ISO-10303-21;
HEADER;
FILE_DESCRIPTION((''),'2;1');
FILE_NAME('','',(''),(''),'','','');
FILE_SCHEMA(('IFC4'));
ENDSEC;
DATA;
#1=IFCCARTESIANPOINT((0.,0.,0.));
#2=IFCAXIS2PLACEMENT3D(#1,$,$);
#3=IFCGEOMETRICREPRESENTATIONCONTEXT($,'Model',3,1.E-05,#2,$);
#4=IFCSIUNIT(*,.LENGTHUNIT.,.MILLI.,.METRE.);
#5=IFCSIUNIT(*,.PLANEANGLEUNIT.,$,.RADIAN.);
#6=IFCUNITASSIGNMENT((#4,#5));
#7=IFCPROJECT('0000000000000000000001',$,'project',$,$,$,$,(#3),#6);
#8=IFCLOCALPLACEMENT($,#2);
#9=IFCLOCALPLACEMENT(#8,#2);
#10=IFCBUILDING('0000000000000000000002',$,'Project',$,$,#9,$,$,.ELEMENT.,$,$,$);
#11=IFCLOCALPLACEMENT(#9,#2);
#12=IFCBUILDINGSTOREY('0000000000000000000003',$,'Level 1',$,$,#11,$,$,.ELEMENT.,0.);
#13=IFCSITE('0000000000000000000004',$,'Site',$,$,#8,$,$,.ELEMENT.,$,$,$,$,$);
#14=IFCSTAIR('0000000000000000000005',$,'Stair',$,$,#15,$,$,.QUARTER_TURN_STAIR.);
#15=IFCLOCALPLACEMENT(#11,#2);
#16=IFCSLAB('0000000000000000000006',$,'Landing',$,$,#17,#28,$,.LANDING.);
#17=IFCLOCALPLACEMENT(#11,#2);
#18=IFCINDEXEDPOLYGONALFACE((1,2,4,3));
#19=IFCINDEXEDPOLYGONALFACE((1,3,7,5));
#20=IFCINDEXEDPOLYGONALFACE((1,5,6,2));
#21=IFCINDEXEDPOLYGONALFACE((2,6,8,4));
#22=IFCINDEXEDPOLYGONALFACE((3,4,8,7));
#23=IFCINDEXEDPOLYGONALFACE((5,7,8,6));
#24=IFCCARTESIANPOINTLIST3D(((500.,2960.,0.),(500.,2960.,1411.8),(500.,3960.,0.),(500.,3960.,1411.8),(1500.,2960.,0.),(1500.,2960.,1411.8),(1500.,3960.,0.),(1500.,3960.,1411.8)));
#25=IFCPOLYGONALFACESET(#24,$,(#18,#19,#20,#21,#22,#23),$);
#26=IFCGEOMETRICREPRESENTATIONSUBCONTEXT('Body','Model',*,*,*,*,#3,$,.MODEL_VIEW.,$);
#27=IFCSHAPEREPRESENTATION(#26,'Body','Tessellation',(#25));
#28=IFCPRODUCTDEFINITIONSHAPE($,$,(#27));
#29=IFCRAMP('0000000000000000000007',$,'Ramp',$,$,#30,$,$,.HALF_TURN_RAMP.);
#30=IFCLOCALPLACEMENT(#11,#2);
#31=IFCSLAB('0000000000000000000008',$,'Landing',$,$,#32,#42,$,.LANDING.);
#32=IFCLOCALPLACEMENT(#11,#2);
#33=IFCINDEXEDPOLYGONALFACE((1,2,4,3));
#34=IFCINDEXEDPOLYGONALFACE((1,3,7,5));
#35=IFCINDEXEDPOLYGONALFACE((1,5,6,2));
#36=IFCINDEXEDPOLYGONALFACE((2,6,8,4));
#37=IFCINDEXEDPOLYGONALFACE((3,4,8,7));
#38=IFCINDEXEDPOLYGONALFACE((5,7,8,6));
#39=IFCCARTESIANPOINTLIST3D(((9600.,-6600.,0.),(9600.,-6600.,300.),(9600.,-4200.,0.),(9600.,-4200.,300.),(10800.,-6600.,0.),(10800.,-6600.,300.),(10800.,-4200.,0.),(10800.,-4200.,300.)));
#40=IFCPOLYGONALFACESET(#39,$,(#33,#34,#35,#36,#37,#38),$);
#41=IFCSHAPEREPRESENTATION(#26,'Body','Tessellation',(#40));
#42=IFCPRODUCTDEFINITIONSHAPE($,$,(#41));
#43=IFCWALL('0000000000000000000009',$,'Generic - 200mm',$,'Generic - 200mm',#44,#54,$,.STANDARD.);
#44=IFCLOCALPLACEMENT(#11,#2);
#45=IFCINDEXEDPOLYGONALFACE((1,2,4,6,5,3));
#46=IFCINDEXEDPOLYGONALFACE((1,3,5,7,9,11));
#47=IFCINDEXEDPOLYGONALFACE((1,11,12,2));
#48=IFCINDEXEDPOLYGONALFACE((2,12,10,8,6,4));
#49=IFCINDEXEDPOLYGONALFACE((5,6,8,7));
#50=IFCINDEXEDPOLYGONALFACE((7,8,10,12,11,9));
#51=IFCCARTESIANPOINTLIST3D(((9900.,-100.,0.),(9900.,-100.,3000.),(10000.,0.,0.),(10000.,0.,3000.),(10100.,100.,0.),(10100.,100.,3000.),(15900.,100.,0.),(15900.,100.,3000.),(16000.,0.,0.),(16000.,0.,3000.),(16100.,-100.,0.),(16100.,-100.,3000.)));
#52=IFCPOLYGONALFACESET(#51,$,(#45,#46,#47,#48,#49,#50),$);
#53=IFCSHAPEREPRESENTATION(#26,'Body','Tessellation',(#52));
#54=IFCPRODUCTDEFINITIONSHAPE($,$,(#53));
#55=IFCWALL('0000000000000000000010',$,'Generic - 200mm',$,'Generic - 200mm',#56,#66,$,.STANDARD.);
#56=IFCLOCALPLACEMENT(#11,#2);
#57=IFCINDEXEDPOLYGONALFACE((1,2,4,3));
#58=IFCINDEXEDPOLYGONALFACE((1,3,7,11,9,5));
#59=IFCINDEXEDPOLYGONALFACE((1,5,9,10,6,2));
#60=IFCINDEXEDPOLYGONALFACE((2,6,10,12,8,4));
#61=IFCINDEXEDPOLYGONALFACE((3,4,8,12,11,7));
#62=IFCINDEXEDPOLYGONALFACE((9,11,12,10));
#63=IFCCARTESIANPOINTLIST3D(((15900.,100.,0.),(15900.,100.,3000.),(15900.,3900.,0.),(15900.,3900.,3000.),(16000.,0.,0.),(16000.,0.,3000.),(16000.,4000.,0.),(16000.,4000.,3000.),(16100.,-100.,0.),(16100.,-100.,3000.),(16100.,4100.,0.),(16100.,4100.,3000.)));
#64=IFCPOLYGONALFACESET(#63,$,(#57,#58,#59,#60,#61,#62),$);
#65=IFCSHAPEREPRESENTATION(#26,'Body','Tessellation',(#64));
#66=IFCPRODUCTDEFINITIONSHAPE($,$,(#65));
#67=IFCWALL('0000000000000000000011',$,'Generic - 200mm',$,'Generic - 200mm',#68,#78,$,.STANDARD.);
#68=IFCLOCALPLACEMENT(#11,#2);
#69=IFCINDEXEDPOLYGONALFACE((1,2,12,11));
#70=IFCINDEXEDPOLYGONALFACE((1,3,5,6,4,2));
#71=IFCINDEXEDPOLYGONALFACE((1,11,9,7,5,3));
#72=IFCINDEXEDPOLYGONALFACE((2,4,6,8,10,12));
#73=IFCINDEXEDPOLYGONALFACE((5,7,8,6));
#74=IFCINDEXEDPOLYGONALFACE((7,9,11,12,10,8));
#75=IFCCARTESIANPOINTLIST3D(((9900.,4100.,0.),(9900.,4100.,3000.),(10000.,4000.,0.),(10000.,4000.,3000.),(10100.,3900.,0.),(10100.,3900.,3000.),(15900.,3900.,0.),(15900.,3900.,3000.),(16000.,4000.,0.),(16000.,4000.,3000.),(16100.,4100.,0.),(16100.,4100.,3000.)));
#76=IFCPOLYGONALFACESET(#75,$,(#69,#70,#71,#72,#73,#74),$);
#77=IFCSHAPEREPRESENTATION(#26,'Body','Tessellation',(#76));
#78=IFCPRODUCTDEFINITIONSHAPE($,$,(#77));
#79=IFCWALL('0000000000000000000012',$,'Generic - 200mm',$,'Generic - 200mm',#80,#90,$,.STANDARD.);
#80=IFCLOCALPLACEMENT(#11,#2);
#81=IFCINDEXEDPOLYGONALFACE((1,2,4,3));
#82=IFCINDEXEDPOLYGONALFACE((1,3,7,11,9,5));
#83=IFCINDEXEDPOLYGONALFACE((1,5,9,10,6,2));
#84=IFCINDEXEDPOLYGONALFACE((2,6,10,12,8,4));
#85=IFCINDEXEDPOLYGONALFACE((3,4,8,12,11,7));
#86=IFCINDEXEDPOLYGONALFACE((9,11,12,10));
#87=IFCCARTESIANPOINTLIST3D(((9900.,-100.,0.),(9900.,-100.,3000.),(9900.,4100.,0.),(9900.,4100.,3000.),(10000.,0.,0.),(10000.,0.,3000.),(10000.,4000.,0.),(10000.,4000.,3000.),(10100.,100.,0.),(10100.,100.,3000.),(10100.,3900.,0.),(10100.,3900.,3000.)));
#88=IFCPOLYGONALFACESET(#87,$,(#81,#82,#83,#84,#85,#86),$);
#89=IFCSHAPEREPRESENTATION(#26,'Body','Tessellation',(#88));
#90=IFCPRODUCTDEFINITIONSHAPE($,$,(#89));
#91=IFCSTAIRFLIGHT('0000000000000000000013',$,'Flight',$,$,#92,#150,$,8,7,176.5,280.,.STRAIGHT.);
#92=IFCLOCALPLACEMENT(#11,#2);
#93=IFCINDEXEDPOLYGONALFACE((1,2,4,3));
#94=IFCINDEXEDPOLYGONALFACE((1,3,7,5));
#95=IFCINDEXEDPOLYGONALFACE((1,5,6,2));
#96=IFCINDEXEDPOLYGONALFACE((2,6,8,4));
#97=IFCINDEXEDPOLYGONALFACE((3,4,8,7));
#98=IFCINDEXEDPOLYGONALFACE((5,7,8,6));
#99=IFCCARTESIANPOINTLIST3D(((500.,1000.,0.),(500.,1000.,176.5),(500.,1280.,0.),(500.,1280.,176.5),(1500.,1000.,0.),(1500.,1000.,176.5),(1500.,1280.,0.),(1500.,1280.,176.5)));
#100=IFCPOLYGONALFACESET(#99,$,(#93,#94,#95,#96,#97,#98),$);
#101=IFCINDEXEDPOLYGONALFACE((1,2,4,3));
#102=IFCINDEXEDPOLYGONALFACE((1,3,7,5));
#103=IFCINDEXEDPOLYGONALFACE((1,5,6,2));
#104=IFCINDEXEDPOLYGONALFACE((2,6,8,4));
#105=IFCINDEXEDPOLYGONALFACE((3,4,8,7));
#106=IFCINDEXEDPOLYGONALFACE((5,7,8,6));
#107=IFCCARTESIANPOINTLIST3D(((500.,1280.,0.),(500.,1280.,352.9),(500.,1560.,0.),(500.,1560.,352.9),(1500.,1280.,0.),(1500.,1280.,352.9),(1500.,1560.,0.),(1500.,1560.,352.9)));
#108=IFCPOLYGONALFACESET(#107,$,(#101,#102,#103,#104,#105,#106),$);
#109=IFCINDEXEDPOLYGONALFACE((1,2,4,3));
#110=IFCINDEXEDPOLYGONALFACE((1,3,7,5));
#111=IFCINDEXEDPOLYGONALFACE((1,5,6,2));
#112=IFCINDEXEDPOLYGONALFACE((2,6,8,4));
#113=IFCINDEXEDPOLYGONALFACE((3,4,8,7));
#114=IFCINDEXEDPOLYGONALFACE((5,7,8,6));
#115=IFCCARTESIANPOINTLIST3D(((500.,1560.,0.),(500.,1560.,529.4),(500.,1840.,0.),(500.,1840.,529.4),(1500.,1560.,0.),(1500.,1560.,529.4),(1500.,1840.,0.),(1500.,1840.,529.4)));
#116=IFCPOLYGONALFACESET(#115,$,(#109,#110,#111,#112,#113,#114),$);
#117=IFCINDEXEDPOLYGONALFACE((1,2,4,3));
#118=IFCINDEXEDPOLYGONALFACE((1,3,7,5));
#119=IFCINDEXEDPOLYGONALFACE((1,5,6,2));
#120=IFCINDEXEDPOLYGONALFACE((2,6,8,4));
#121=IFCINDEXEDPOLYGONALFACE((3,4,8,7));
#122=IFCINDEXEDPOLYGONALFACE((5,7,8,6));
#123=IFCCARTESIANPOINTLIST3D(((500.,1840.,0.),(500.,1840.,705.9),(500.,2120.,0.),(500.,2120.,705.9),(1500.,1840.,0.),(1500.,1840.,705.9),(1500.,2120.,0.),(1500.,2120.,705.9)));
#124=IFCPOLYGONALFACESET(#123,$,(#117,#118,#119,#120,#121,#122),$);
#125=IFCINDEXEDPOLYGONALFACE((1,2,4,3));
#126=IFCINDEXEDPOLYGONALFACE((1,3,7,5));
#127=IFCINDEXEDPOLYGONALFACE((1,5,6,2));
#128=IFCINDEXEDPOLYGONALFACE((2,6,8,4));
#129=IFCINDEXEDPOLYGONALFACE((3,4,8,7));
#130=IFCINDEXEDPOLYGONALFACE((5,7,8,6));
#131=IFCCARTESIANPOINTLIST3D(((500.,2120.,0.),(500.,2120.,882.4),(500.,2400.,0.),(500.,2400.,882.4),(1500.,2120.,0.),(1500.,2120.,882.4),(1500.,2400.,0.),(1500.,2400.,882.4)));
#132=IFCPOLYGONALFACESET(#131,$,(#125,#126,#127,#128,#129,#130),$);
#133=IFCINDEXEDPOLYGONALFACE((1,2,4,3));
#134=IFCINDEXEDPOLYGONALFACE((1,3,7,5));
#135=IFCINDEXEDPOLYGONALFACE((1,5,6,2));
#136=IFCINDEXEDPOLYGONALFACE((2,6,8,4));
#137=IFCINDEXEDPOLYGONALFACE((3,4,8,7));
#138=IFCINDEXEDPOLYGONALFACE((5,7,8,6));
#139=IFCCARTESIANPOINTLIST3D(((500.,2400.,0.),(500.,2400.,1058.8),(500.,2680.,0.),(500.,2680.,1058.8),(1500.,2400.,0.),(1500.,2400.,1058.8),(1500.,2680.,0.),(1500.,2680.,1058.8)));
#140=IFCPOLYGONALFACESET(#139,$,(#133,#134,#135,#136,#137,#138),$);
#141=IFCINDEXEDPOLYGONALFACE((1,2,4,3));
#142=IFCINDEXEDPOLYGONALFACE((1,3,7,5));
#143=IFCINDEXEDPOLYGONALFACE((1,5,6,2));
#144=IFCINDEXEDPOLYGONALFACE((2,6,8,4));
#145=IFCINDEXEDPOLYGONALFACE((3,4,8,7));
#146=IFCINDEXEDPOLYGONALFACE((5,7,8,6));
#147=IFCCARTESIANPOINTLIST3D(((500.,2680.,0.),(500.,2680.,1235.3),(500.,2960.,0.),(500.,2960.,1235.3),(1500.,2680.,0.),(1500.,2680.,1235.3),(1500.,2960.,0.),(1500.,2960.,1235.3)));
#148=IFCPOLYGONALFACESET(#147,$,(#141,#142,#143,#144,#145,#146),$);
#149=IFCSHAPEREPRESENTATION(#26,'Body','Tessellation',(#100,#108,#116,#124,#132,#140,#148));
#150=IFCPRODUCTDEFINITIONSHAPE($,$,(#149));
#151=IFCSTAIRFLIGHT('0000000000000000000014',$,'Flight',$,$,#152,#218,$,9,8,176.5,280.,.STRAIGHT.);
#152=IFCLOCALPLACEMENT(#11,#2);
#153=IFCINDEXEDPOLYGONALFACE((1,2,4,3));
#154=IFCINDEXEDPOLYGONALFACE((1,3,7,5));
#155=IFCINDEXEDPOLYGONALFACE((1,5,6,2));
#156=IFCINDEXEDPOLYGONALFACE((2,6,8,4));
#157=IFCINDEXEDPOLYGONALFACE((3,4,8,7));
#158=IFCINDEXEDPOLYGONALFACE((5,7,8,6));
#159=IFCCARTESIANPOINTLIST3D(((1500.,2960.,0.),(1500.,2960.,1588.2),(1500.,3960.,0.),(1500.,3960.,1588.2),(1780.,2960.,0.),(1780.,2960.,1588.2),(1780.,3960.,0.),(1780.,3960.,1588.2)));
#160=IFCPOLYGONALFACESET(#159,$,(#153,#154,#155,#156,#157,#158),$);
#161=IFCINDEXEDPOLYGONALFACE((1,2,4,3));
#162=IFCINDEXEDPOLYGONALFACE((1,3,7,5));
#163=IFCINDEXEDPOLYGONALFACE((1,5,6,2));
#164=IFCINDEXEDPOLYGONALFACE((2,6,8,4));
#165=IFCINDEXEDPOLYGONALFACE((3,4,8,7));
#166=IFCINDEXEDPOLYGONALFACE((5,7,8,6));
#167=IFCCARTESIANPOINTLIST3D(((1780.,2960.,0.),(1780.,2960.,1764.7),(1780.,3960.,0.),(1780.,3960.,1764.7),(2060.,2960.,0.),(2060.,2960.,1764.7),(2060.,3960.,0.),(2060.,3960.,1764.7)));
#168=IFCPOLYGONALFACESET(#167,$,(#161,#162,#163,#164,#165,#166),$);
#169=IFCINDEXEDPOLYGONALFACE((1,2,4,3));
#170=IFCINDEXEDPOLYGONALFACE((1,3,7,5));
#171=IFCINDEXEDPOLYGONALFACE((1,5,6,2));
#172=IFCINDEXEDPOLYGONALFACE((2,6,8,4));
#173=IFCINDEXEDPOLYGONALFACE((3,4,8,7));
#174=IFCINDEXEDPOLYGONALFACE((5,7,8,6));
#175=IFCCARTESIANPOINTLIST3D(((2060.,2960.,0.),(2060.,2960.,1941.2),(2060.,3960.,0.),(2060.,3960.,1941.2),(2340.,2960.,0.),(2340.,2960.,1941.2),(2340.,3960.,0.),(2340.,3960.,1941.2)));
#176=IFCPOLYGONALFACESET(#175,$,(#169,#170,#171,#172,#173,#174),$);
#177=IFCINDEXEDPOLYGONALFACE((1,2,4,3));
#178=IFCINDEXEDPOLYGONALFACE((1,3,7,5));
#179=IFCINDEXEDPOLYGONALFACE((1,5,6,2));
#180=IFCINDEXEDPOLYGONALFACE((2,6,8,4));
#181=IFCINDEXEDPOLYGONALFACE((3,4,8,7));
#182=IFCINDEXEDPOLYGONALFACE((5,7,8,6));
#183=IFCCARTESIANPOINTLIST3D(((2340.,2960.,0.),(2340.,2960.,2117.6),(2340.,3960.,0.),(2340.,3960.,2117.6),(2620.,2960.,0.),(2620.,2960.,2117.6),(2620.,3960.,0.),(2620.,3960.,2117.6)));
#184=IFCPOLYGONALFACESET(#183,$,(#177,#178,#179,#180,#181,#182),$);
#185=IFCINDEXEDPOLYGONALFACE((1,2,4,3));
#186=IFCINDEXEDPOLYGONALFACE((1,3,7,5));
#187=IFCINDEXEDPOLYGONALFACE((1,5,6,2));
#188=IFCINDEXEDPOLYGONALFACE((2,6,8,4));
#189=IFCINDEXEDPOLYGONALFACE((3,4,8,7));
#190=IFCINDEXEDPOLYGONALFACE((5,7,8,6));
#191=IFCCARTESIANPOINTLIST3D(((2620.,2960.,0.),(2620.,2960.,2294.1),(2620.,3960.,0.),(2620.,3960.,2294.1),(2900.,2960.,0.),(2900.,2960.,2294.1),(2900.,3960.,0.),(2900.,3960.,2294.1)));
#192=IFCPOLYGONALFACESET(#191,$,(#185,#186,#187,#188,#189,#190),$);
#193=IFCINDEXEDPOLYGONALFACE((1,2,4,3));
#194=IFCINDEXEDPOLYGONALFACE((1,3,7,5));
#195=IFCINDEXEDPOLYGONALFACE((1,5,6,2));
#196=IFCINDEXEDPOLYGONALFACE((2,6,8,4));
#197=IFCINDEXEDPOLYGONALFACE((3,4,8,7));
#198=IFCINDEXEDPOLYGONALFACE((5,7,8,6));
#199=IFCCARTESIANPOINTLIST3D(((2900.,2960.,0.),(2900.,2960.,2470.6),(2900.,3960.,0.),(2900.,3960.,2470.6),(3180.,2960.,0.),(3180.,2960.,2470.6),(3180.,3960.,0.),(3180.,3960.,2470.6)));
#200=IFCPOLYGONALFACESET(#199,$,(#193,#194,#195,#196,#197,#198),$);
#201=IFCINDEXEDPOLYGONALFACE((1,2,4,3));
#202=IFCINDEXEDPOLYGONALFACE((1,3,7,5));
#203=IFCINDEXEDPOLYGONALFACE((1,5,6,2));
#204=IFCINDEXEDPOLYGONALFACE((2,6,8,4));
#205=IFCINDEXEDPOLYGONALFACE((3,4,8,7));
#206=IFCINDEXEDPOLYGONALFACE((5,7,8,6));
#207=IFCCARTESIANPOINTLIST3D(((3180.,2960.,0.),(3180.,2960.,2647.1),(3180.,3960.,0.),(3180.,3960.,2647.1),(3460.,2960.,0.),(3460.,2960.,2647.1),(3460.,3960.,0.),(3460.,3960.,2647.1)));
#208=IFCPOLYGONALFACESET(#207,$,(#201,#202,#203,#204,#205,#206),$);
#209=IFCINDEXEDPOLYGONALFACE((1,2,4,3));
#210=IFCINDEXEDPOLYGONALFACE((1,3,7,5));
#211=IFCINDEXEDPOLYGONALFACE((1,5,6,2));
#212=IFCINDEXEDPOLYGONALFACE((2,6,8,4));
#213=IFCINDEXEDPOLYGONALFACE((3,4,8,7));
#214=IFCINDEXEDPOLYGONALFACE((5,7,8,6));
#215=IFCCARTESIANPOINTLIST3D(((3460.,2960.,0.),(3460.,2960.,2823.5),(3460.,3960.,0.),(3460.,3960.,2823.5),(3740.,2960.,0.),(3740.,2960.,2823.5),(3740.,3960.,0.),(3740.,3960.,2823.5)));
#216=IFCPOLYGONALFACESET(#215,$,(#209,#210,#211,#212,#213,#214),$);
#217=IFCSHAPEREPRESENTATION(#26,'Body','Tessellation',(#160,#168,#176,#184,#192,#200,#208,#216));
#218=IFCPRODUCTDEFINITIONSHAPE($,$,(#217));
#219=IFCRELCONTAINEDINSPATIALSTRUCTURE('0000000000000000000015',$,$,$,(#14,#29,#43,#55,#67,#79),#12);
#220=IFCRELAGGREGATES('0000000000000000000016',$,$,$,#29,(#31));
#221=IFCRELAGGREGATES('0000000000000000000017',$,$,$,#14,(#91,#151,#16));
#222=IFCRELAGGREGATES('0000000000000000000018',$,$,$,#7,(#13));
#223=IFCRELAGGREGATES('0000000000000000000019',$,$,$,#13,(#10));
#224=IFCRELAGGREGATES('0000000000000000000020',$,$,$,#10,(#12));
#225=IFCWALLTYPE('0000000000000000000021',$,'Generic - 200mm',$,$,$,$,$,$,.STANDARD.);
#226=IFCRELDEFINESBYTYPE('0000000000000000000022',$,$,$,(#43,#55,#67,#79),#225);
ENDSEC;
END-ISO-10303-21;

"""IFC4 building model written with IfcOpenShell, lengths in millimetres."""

from ifc_helpers import new_model, si_unit, frame, frame_2d, origin, place, context, subcontext, project, spatial, polyline, rectangle, outline, extrude, type_object, element, aggregate, save


model = new_model("IFC4")

# Units and contexts
model_context = context("Model", 3, precision=1e-05, world=origin())
body_context = subcontext(model_context, "Body", "Model", "MODEL_VIEW")
ifc_project = project(units=[si_unit("LENGTHUNIT", "METRE", prefix="MILLI"), si_unit("PLANEANGLEUNIT", "RADIAN")], contexts=[model_context])

# Site, building, storey
site_placement = place(None, origin())
site = spatial("IfcSite", under=ifc_project, at=site_placement, Name="Site", CompositionType="ELEMENT")
building_placement = place(site_placement, origin())
building = spatial("IfcBuilding", under=site, at=building_placement, Name="Project", CompositionType="ELEMENT")
storey_placement = place(building_placement, origin())
storey = spatial("IfcBuildingStorey", under=building, at=storey_placement, Name="Level 1", CompositionType="ELEMENT", Elevation=0.0)

# Stair, slab
stair_placement = place(storey_placement, origin())
stair = element("IfcStair", 1, at=stair_placement, inside=storey, Name="Stair", PredefinedType="QUARTER_TURN_STAIR")
slab_1_placement = place(stair_placement, origin())
slab_1 = element("IfcSlab", 2, at=slab_1_placement, Name="Landing", PredefinedType="LANDING", context=body_context, shape_type="SweptSolid", body=[
    extrude(outline(polyline([(1500.0, 2960.0), (1500.0, 3960.0), (500.0, 3960.0), (500.0, 2960.0), (1500.0, 2960.0)])), origin(), (0.0, 0.0, 1.0), 1411.8),
])

# Ramp, slab
ramp_placement = place(storey_placement, origin())
ramp = element("IfcRamp", 3, at=ramp_placement, inside=storey, Name="Ramp", PredefinedType="HALF_TURN_RAMP")
slab_2_placement = place(ramp_placement, origin())
slab_2 = element("IfcSlab", 4, at=slab_2_placement, Name="Landing", PredefinedType="LANDING", context=body_context, shape_type="SweptSolid", body=[
    extrude(outline(polyline([(9600.0, -6600.0), (10800.0, -6600.0), (10800.0, -4200.0), (9600.0, -4200.0), (9600.0, -6600.0)])), origin(), (0.0, 0.0, 1.0), 300.0),
])
aggregate(ramp, [slab_2])

# Walls
wall_type = type_object("IfcWallType", Name="Generic - 200mm", PredefinedType="STANDARD")
wall_1_placement = place(storey_placement, frame((10000.0, 0.0, 0.0), z_axis=(0.0, 0.0, 1.0), x_axis=(1.0, 0.0, 0.0)))
element("IfcWall", 5, at=wall_1_placement, inside=storey, type_object=wall_type, Name="Generic - 200mm", ObjectType="Generic - 200mm", PredefinedType="STANDARD", context=body_context, shape_type="SweptSolid", body=[
    extrude(outline(polyline([(-100.0, -100.0), (0.0, 0.0), (100.0, 100.0), (5900.0, 100.0), (6000.0, 0.0), (6100.0, -100.0), (-100.0, -100.0)])), origin(), (0.0, 0.0, 1.0), 3000.0),
])
wall_2_placement = place(storey_placement, frame((16000.0, 0.0, 0.0), z_axis=(0.0, 0.0, 1.0), x_axis=(0.0, 1.0, 0.0)))
element("IfcWall", 6, at=wall_2_placement, inside=storey, type_object=wall_type, Name="Generic - 200mm", ObjectType="Generic - 200mm", PredefinedType="STANDARD", context=body_context, shape_type="SweptSolid", body=[
    extrude(outline(polyline([(-100.0, -100.0), (0.0, 0.0), (100.0, 100.0), (3900.0, 100.0), (4000.0, 0.0), (4100.0, -100.0), (-100.0, -100.0)])), origin(), (0.0, 0.0, 1.0), 3000.0),
])
wall_3_placement = place(storey_placement, frame((16000.0, 4000.0, 0.0), z_axis=(0.0, 0.0, 1.0), x_axis=(-1.0, 0.0, 0.0)))
element("IfcWall", 7, at=wall_3_placement, inside=storey, type_object=wall_type, Name="Generic - 200mm", ObjectType="Generic - 200mm", PredefinedType="STANDARD", context=body_context, shape_type="SweptSolid", body=[
    extrude(outline(polyline([(-100.0, -100.0), (0.0, 0.0), (100.0, 100.0), (5900.0, 100.0), (6000.0, 0.0), (6100.0, -100.0), (-100.0, -100.0)])), origin(), (0.0, 0.0, 1.0), 3000.0),
])
wall_4_placement = place(storey_placement, frame((10000.0, 4000.0, 0.0), z_axis=(0.0, 0.0, 1.0), x_axis=(0.0, -1.0, 0.0)))
element("IfcWall", 8, at=wall_4_placement, inside=storey, type_object=wall_type, Name="Generic - 200mm", ObjectType="Generic - 200mm", PredefinedType="STANDARD", context=body_context, shape_type="SweptSolid", body=[
    extrude(outline(polyline([(-100.0, -100.0), (0.0, 0.0), (100.0, 100.0), (3900.0, 100.0), (4000.0, 0.0), (4100.0, -100.0), (-100.0, -100.0)])), origin(), (0.0, 0.0, 1.0), 3000.0),
])

# Stair flights
stair_flight_1_placement = place(stair_placement, frame((1000.0, 1000.0, 0.0), z_axis=(0.0, 0.0, 1.0), x_axis=(0.0, 1.0, 0.0)))
stair_flight_1 = element("IfcStairFlight", 9, at=stair_flight_1_placement, Name="Flight", NumberOfRisers=8, NumberOfTreads=7, PredefinedType="STRAIGHT", RiserHeight=176.5, TreadLength=280.0, context=body_context, shape_type="SweptSolid", body=[
    extrude(rectangle(XDim=280.0, YDim=1000.0, at=frame_2d((140.0, 0.0))), origin(), (0.0, 0.0, 1.0), 176.5),
    extrude(rectangle(XDim=280.0, YDim=1000.0, at=frame_2d((420.0, 0.0))), origin(), (0.0, 0.0, 1.0), 352.9),
    extrude(rectangle(XDim=280.0, YDim=1000.0, at=frame_2d((700.0, 0.0))), origin(), (0.0, 0.0, 1.0), 529.4),
    extrude(rectangle(XDim=280.0, YDim=1000.0, at=frame_2d((980.0, 0.0))), origin(), (0.0, 0.0, 1.0), 705.9),
    extrude(rectangle(XDim=280.0, YDim=1000.0, at=frame_2d((1260.0, 0.0))), origin(), (0.0, 0.0, 1.0), 882.4),
    extrude(rectangle(XDim=280.0, YDim=1000.0, at=frame_2d((1540.0, 0.0))), origin(), (0.0, 0.0, 1.0), 1058.8),
    extrude(rectangle(XDim=280.0, YDim=1000.0, at=frame_2d((1820.0, 0.0))), origin(), (0.0, 0.0, 1.0), 1235.3),
])
stair_flight_2_placement = place(stair_placement, frame((1500.0, 3460.0, 1411.8), z_axis=(0.0, 0.0, 1.0), x_axis=(1.0, 0.0, 0.0)))
stair_flight_2 = element("IfcStairFlight", 10, at=stair_flight_2_placement, Name="Flight", NumberOfRisers=9, NumberOfTreads=8, PredefinedType="STRAIGHT", RiserHeight=176.5, TreadLength=280.0, context=body_context, shape_type="SweptSolid", body=[
    extrude(rectangle(XDim=280.0, YDim=1000.0, at=frame_2d((140.0, 0.0))), frame((0.0, 0.0, -1411.8)), (0.0, 0.0, 1.0), 1588.2),
    extrude(rectangle(XDim=280.0, YDim=1000.0, at=frame_2d((420.0, 0.0))), frame((0.0, 0.0, -1411.8)), (0.0, 0.0, 1.0), 1764.7),
    extrude(rectangle(XDim=280.0, YDim=1000.0, at=frame_2d((700.0, 0.0))), frame((0.0, 0.0, -1411.8)), (0.0, 0.0, 1.0), 1941.2),
    extrude(rectangle(XDim=280.0, YDim=1000.0, at=frame_2d((980.0, 0.0))), frame((0.0, 0.0, -1411.8)), (0.0, 0.0, 1.0), 2117.6),
    extrude(rectangle(XDim=280.0, YDim=1000.0, at=frame_2d((1260.0, 0.0))), frame((0.0, 0.0, -1411.8)), (0.0, 0.0, 1.0), 2294.1),
    extrude(rectangle(XDim=280.0, YDim=1000.0, at=frame_2d((1540.0, 0.0))), frame((0.0, 0.0, -1411.8)), (0.0, 0.0, 1.0), 2470.6),
    extrude(rectangle(XDim=280.0, YDim=1000.0, at=frame_2d((1820.0, 0.0))), frame((0.0, 0.0, -1411.8)), (0.0, 0.0, 1.0), 2647.1),
    extrude(rectangle(XDim=280.0, YDim=1000.0, at=frame_2d((2100.0, 0.0))), frame((0.0, 0.0, -1411.8)), (0.0, 0.0, 1.0), 2823.5),
])
aggregate(stair, [stair_flight_1, stair_flight_2, slab_1])

save(model, "model.ifc")
